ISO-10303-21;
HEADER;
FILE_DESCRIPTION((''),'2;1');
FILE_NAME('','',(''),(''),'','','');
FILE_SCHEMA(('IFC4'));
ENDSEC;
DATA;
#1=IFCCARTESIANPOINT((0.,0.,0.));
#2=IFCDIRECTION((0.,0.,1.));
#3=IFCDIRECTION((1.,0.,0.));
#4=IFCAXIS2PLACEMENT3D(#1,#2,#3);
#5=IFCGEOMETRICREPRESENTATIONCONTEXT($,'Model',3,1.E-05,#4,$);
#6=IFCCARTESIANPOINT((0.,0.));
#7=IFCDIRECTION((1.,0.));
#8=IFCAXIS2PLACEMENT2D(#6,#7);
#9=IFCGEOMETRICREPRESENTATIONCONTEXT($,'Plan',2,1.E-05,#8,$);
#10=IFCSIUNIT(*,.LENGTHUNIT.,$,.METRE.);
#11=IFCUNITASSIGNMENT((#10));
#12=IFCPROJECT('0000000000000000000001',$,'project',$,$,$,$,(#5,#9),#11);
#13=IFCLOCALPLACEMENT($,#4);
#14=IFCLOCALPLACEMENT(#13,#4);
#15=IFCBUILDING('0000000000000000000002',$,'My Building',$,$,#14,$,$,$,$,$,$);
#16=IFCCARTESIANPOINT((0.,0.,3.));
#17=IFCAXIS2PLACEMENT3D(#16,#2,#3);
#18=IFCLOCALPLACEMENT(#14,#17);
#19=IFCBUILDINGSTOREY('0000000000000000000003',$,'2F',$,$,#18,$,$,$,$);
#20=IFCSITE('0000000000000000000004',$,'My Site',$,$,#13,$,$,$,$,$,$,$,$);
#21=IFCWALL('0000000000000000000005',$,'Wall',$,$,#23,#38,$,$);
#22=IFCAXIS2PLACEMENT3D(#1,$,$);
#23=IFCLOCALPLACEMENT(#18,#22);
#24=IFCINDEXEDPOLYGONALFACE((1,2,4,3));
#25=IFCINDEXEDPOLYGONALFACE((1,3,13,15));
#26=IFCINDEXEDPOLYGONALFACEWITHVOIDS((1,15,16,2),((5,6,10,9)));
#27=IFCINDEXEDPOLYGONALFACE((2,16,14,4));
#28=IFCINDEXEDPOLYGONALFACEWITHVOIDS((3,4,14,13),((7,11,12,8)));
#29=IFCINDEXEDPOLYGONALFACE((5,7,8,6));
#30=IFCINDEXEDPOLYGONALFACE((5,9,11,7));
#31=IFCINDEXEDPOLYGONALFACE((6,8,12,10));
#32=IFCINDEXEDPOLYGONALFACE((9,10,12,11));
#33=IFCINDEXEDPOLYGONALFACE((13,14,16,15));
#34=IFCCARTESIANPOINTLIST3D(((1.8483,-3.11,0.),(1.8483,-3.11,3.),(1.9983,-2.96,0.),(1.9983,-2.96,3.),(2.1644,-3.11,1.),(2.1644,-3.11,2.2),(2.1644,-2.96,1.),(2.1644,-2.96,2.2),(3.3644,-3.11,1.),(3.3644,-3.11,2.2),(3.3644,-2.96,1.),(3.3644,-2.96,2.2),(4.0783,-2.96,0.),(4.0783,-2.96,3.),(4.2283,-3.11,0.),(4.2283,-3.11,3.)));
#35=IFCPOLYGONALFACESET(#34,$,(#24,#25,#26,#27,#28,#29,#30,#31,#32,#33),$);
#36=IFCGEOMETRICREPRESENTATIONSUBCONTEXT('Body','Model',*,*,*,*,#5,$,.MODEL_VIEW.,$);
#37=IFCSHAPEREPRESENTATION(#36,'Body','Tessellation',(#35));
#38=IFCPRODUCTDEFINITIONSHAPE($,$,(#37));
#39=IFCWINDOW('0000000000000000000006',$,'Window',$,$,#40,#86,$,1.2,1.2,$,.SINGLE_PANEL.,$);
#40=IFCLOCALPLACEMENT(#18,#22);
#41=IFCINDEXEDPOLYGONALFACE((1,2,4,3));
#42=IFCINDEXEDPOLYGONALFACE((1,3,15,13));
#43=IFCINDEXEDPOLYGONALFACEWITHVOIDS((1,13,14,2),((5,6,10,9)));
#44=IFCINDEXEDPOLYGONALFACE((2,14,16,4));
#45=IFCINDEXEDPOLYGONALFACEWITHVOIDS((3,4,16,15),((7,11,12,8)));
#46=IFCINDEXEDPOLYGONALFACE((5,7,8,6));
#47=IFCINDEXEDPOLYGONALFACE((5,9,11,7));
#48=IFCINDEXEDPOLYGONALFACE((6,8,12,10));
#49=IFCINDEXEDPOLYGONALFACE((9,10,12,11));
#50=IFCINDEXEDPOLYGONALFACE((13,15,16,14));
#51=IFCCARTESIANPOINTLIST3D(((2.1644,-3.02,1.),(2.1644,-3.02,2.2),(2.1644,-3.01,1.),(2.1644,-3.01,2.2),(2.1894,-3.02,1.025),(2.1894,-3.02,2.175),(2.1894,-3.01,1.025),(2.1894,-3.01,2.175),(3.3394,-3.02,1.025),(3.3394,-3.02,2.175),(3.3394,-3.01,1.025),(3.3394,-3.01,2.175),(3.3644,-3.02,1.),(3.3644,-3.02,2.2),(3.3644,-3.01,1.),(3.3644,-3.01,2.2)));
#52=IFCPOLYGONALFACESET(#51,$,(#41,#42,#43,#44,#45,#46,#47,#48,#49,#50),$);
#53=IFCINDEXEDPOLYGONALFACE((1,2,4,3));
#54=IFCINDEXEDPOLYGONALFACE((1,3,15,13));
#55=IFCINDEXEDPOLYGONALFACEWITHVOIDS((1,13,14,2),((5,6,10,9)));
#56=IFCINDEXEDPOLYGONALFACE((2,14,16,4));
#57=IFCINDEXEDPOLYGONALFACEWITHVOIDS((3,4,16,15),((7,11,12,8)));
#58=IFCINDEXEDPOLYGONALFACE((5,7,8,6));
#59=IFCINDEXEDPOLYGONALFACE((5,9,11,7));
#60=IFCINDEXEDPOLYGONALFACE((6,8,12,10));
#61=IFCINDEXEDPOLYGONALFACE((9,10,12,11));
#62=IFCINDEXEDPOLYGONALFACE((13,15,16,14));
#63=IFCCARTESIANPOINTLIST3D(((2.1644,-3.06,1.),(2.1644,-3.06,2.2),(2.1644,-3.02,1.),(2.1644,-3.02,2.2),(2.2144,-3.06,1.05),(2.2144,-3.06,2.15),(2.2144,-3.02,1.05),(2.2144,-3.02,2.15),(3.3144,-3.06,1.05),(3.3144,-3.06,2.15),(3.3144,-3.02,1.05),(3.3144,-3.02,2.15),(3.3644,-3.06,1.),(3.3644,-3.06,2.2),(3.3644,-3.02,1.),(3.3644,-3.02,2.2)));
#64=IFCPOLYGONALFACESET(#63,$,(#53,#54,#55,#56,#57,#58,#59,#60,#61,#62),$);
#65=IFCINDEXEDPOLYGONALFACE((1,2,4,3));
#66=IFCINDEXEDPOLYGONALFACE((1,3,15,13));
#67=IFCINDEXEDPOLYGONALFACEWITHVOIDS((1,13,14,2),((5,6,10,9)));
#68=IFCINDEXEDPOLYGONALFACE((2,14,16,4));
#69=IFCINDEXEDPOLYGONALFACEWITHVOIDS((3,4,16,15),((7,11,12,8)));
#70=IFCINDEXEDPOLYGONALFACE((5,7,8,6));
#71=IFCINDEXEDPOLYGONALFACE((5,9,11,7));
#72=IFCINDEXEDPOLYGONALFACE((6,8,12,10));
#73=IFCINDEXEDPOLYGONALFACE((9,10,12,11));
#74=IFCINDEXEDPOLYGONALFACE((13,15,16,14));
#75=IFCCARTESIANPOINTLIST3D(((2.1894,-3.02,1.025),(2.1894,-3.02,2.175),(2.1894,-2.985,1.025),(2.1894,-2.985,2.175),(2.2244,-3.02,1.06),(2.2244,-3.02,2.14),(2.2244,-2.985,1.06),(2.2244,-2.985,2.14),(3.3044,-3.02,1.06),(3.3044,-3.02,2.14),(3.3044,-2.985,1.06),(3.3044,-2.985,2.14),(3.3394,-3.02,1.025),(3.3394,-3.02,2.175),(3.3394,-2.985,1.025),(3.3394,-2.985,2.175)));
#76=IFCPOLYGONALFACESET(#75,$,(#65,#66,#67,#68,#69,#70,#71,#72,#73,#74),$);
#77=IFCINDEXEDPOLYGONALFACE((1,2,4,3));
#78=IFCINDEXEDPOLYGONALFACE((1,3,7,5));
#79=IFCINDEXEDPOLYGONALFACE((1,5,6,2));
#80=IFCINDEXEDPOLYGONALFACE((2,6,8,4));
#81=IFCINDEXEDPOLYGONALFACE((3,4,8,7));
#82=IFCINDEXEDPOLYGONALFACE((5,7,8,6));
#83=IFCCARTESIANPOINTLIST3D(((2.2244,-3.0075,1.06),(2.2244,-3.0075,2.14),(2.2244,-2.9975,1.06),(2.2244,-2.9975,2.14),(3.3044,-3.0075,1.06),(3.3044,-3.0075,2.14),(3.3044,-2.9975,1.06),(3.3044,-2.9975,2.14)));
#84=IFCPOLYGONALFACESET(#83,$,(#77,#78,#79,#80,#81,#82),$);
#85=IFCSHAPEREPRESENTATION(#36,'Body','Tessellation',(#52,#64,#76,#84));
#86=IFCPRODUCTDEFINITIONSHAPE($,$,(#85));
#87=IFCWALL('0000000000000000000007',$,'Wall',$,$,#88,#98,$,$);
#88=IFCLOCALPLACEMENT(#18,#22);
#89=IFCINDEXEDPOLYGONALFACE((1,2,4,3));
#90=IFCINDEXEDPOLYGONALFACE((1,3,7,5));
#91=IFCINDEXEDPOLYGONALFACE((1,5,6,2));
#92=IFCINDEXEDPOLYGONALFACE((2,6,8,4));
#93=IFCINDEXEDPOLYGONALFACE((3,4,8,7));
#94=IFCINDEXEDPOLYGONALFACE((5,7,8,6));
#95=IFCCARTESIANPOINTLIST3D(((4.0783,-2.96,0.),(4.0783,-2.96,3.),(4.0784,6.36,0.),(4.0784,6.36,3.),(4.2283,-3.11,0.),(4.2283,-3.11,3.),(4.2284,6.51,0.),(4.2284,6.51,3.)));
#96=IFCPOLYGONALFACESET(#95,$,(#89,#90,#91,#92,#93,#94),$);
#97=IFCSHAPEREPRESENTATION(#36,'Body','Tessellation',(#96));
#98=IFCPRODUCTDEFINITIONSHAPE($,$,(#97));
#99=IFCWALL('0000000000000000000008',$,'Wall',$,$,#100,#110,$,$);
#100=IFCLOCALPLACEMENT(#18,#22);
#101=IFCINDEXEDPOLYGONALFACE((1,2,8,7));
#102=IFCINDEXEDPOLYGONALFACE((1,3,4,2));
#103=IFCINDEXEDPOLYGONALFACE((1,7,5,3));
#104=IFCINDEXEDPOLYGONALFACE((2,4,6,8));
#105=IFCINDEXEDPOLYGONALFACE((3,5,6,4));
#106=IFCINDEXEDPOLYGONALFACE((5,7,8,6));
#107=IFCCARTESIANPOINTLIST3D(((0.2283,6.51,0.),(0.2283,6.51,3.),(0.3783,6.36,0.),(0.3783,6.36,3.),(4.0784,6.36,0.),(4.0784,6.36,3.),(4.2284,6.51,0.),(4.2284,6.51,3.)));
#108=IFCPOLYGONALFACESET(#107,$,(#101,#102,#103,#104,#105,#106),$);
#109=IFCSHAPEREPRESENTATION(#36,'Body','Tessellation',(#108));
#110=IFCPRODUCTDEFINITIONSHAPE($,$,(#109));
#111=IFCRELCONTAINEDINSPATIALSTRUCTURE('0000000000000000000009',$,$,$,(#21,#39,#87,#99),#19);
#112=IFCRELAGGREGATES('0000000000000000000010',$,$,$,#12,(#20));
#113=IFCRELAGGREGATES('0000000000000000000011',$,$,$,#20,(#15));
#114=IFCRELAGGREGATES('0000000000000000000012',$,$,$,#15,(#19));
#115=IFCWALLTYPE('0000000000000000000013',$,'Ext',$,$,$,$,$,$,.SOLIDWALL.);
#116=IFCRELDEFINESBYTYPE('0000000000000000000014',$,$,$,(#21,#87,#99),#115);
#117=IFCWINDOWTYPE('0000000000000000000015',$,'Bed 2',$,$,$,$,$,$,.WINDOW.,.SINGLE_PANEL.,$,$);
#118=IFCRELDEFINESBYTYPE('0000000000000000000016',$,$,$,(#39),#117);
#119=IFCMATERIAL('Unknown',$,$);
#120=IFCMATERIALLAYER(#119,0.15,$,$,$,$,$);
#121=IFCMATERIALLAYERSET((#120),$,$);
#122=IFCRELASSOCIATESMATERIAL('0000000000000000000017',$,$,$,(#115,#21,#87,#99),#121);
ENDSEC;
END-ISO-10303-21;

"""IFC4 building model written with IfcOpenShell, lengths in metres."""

from ifc_helpers import new_model, entity, si_unit, frame, origin_with_axes, origin_2d_with_axis, place, context, subcontext, project, spatial, line, indexed_curve, outline, extrude, shape, source, transform, mapped, material, layer, layer_set, layer_usage, type_object, type_shapes, element, fill, save


model = new_model("IFC4")

# Units and contexts
model_context = context("Model", 3, precision=1e-05, world=origin_with_axes())
plan_context = context("Plan", 2, precision=1e-05, world=origin_2d_with_axis())
body_context_1 = subcontext(model_context, "Body", "Model", "MODEL_VIEW")
body_context_2 = subcontext(plan_context, "Body", "Plan", "PLAN_VIEW")
ifc_project = project(units=[si_unit("LENGTHUNIT", "METRE")], contexts=[model_context, plan_context])

# Site, building, storey
site_placement = place(None, origin_with_axes())
site = spatial("IfcSite", under=ifc_project, at=site_placement, Name="My Site")
building_placement = place(site_placement, origin_with_axes())
building = spatial("IfcBuilding", under=site, at=building_placement, Name="My Building")
storey_placement = place(building_placement, frame((0.0, 0.0, 3.0), z_axis=(0.0, 0.0, 1.0), x_axis=(1.0, 0.0, 0.0)))
storey = spatial("IfcBuildingStorey", under=building, at=storey_placement, Name="2F")

# Shared definitions
ifc_material = material(Name="Unknown")
ifc_layer_1 = layer(ifc_material, 0.15)
ifc_layer_set_1 = layer_set([ifc_layer_1])
wall_type_1 = type_object("IfcWallType", Name="Ext", PredefinedType="SOLIDWALL", material=ifc_layer_set_1)

# Wall, opening, window
ifc_layer_usage_1 = layer_usage(ifc_layer_set_1, "AXIS2", "POSITIVE", 0.0)
wall_1_placement = place(storey_placement, frame((1.8483, -3.11, 0.0), z_axis=(0.0, 0.0, 1.0), x_axis=(1.0, 0.0, 0.0)))
wall_1 = element("IfcWall", 1, at=wall_1_placement, inside=storey, type_object=wall_type_1, material=ifc_layer_usage_1, Name="Wall", context=body_context_1, shape_type="SweptSolid", body=[
    extrude(outline(indexed_curve([(0.0, 0.0), (0.15, 0.15), (2.23, 0.15), (2.38, 0.0)], segments=[line(1, 2, 3, 4, 1)])), origin_with_axes(), (0.0, 0.0, 1.0), 3.0),
])
shared_shape_1 = source(origin_with_axes(), body_context_1, "Body", "SweptSolid", [
    extrude(outline(indexed_curve([(0.0, 0.0), (1.2, 0.0), (1.2, 1.2), (0.0, 1.2)], segments=[line(1, 2, 3, 4, 1)])), frame((0.0, -0.6, 0.0), z_axis=(0.0, -1.0, 0.0), x_axis=(1.0, 0.0, 0.0)), (0.0, 0.0, -1.0), 1.2),
])
opening_1_placement = place(wall_1_placement, frame((0.316, 0.0, 1.0), z_axis=(0.0, 0.0, 1.0), x_axis=(1.0, 0.0, 0.0)))
opening_1 = element("IfcOpeningElement", 2, at=opening_1_placement, cuts=wall_1, PredefinedType="OPENING", context=body_context_1, shape_type="MappedRepresentation", body=[
    mapped(shared_shape_1, transform((0.0, 0.0, 0.0), x_axis=(1.0, 0.0, 0.0), y_axis=(0.0, 1.0, 0.0), z_axis=(0.0, 0.0, 1.0), scale=1.0)),
])
window_type_1 = type_object("IfcWindowType", Name="Bed 2", PartitioningType="SINGLE_PANEL", PredefinedType="WINDOW")
shared_shape_2 = source(origin_with_axes(), body_context_1, "Body", "SweptSolid", [
    extrude(outline(indexed_curve([(0.0, 0.0), (1.2, 0.0), (1.2, 1.2), (0.0, 1.2)], segments=[line(1, 2, 3, 4, 1)]), holes=[indexed_curve([(0.025, 0.025), (1.175, 0.025), (1.175, 1.175), (0.025, 1.175)], segments=[line(1, 2, 3, 4, 1)])]), frame((0.0, 0.09, 0.0), z_axis=(0.0, -1.0, 0.0), x_axis=(1.0, 0.0, 0.0)), (0.0, 0.0, -1.0), 0.01),
    extrude(outline(indexed_curve([(0.0, 0.0), (1.2, 0.0), (1.2, 1.2), (0.0, 1.2)], segments=[line(1, 2, 3, 4, 1)]), holes=[indexed_curve([(0.05, 0.05), (1.15, 0.05), (1.15, 1.15), (0.05, 1.15)], segments=[line(1, 2, 3, 4, 1)])]), frame((0.0, 0.05, 0.0), z_axis=(0.0, -1.0, 0.0), x_axis=(1.0, 0.0, 0.0)), (0.0, 0.0, -1.0), 0.04),
    extrude(outline(indexed_curve([(0.0, 0.0), (1.15, 0.0), (1.15, 1.15), (0.0, 1.15)], segments=[line(1, 2, 3, 4, 1)]), holes=[indexed_curve([(0.035, 0.035), (1.115, 0.035), (1.115, 1.115), (0.035, 1.115)], segments=[line(1, 2, 3, 4, 1)])]), frame((0.025, 0.09, 0.025), z_axis=(0.0, -1.0, 0.0), x_axis=(1.0, 0.0, 0.0)), (0.0, 0.0, -1.0), 0.035),
    extrude(outline(indexed_curve([(0.035, 0.035), (1.115, 0.035), (1.115, 1.115), (0.035, 1.115)], segments=[line(1, 2, 3, 4, 1)])), frame((0.025, 0.1025, 0.025), z_axis=(0.0, -1.0, 0.0), x_axis=(1.0, 0.0, 0.0)), (0.0, 0.0, -1.0), 0.01),
])
shared_shape_3 = source(origin_with_axes(), body_context_2, "Body", "Curve2D", [
    entity("IfcIndexedPolyCurve", entity("IfcCartesianPointList2D", [[0.05, 0.05], [1.15, 0.05]])),
    entity("IfcIndexedPolyCurve", entity("IfcCartesianPointList2D", [[0.0, 0.1], [0.025, 0.1], [0.025, 0.09], [0.05, 0.09], [0.05, 0.05], [0.0, 0.05]]), [entity("IfcLineIndex", [1, 2, 3, 4, 5, 6, 1])]),
    entity("IfcIndexedPolyCurve", entity("IfcCartesianPointList2D", [[1.2, 0.1], [1.175, 0.1], [1.175, 0.09], [1.15, 0.09], [1.15, 0.05], [1.2, 0.05]]), [entity("IfcLineIndex", [1, 2, 3, 4, 5, 6, 1])]),
    entity("IfcIndexedPolyCurve", entity("IfcCartesianPointList2D", [[0.025, 0.09], [0.06, 0.09], [0.06, 0.125], [0.025, 0.125]]), [entity("IfcLineIndex", [1, 2, 3, 4, 1])]),
    entity("IfcIndexedPolyCurve", entity("IfcCartesianPointList2D", [[1.175, 0.09], [1.14, 0.09], [1.14, 0.125], [1.175, 0.125]]), [entity("IfcLineIndex", [1, 2, 3, 4, 1])]),
    entity("IfcIndexedPolyCurve", entity("IfcCartesianPointList2D", [[0.06, 0.09], [1.14, 0.09]])),
    entity("IfcIndexedPolyCurve", entity("IfcCartesianPointList2D", [[0.06, 0.125], [1.14, 0.125]])),
    entity("IfcIndexedPolyCurve", entity("IfcCartesianPointList2D", [[0.06, 0.1075], [1.14, 0.1075]])),
])
type_shapes(window_type_1, [shared_shape_2, shared_shape_3])
window_1_placement = place(opening_1_placement, frame((0.0, 0.0, 0.0), z_axis=(0.0, 0.0, 1.0), x_axis=(1.0, 0.0, 0.0)))
window_1 = element("IfcWindow", 3, at=window_1_placement, inside=storey, type_object=window_type_1, Name="Window", OverallHeight=1.2, OverallWidth=1.2, PartitioningType="SINGLE_PANEL", shapes=[
    shape(body_context_1, "Body", "MappedRepresentation", [mapped(shared_shape_2, transform((0.0, 0.0, 0.0), x_axis=(1.0, 0.0, 0.0), y_axis=(0.0, 1.0, 0.0), z_axis=(0.0, 0.0, 1.0), scale=1.0))]),
    shape(body_context_2, "Body", "MappedRepresentation", [mapped(shared_shape_3, transform((0.0, 0.0, 0.0), x_axis=(1.0, 0.0, 0.0), y_axis=(0.0, 1.0, 0.0), z_axis=(0.0, 0.0, 1.0), scale=1.0))]),
])
fill(opening_1, window_1)

# Walls
ifc_layer_usage_2 = layer_usage(ifc_layer_set_1, "AXIS2", "POSITIVE", 0.0)
wall_2_placement = place(storey_placement, frame((4.2283, -3.11, 0.0), z_axis=(0.0, 0.0, 1.0), x_axis=(0.0, 1.0, 0.0)))
element("IfcWall", 4, at=wall_2_placement, inside=storey, type_object=wall_type_1, material=ifc_layer_usage_2, Name="Wall", context=body_context_1, shape_type="SweptSolid", body=[
    extrude(outline(indexed_curve([(0.0, 0.0), (0.15, 0.15), (9.47, 0.15), (9.62, 0.0)], segments=[line(1, 2, 3, 4, 1)])), origin_with_axes(), (0.0, 0.0, 1.0), 3.0),
])
ifc_layer_usage_3 = layer_usage(ifc_layer_set_1, "AXIS2", "POSITIVE", 0.0)
wall_3_placement = place(storey_placement, frame((4.2284, 6.51, 0.0), z_axis=(0.0, 0.0, 1.0), x_axis=(-1.0, 0.0, 0.0)))
element("IfcWall", 5, at=wall_3_placement, inside=storey, type_object=wall_type_1, material=ifc_layer_usage_3, Name="Wall", context=body_context_1, shape_type="SweptSolid", body=[
    extrude(outline(indexed_curve([(0.0, 0.0), (0.15, 0.15), (3.85, 0.15), (4.0, 0.0)], segments=[line(1, 2, 3, 4, 1)])), origin_with_axes(), (0.0, 0.0, 1.0), 3.0),
])

save(model, "model.ifc")
